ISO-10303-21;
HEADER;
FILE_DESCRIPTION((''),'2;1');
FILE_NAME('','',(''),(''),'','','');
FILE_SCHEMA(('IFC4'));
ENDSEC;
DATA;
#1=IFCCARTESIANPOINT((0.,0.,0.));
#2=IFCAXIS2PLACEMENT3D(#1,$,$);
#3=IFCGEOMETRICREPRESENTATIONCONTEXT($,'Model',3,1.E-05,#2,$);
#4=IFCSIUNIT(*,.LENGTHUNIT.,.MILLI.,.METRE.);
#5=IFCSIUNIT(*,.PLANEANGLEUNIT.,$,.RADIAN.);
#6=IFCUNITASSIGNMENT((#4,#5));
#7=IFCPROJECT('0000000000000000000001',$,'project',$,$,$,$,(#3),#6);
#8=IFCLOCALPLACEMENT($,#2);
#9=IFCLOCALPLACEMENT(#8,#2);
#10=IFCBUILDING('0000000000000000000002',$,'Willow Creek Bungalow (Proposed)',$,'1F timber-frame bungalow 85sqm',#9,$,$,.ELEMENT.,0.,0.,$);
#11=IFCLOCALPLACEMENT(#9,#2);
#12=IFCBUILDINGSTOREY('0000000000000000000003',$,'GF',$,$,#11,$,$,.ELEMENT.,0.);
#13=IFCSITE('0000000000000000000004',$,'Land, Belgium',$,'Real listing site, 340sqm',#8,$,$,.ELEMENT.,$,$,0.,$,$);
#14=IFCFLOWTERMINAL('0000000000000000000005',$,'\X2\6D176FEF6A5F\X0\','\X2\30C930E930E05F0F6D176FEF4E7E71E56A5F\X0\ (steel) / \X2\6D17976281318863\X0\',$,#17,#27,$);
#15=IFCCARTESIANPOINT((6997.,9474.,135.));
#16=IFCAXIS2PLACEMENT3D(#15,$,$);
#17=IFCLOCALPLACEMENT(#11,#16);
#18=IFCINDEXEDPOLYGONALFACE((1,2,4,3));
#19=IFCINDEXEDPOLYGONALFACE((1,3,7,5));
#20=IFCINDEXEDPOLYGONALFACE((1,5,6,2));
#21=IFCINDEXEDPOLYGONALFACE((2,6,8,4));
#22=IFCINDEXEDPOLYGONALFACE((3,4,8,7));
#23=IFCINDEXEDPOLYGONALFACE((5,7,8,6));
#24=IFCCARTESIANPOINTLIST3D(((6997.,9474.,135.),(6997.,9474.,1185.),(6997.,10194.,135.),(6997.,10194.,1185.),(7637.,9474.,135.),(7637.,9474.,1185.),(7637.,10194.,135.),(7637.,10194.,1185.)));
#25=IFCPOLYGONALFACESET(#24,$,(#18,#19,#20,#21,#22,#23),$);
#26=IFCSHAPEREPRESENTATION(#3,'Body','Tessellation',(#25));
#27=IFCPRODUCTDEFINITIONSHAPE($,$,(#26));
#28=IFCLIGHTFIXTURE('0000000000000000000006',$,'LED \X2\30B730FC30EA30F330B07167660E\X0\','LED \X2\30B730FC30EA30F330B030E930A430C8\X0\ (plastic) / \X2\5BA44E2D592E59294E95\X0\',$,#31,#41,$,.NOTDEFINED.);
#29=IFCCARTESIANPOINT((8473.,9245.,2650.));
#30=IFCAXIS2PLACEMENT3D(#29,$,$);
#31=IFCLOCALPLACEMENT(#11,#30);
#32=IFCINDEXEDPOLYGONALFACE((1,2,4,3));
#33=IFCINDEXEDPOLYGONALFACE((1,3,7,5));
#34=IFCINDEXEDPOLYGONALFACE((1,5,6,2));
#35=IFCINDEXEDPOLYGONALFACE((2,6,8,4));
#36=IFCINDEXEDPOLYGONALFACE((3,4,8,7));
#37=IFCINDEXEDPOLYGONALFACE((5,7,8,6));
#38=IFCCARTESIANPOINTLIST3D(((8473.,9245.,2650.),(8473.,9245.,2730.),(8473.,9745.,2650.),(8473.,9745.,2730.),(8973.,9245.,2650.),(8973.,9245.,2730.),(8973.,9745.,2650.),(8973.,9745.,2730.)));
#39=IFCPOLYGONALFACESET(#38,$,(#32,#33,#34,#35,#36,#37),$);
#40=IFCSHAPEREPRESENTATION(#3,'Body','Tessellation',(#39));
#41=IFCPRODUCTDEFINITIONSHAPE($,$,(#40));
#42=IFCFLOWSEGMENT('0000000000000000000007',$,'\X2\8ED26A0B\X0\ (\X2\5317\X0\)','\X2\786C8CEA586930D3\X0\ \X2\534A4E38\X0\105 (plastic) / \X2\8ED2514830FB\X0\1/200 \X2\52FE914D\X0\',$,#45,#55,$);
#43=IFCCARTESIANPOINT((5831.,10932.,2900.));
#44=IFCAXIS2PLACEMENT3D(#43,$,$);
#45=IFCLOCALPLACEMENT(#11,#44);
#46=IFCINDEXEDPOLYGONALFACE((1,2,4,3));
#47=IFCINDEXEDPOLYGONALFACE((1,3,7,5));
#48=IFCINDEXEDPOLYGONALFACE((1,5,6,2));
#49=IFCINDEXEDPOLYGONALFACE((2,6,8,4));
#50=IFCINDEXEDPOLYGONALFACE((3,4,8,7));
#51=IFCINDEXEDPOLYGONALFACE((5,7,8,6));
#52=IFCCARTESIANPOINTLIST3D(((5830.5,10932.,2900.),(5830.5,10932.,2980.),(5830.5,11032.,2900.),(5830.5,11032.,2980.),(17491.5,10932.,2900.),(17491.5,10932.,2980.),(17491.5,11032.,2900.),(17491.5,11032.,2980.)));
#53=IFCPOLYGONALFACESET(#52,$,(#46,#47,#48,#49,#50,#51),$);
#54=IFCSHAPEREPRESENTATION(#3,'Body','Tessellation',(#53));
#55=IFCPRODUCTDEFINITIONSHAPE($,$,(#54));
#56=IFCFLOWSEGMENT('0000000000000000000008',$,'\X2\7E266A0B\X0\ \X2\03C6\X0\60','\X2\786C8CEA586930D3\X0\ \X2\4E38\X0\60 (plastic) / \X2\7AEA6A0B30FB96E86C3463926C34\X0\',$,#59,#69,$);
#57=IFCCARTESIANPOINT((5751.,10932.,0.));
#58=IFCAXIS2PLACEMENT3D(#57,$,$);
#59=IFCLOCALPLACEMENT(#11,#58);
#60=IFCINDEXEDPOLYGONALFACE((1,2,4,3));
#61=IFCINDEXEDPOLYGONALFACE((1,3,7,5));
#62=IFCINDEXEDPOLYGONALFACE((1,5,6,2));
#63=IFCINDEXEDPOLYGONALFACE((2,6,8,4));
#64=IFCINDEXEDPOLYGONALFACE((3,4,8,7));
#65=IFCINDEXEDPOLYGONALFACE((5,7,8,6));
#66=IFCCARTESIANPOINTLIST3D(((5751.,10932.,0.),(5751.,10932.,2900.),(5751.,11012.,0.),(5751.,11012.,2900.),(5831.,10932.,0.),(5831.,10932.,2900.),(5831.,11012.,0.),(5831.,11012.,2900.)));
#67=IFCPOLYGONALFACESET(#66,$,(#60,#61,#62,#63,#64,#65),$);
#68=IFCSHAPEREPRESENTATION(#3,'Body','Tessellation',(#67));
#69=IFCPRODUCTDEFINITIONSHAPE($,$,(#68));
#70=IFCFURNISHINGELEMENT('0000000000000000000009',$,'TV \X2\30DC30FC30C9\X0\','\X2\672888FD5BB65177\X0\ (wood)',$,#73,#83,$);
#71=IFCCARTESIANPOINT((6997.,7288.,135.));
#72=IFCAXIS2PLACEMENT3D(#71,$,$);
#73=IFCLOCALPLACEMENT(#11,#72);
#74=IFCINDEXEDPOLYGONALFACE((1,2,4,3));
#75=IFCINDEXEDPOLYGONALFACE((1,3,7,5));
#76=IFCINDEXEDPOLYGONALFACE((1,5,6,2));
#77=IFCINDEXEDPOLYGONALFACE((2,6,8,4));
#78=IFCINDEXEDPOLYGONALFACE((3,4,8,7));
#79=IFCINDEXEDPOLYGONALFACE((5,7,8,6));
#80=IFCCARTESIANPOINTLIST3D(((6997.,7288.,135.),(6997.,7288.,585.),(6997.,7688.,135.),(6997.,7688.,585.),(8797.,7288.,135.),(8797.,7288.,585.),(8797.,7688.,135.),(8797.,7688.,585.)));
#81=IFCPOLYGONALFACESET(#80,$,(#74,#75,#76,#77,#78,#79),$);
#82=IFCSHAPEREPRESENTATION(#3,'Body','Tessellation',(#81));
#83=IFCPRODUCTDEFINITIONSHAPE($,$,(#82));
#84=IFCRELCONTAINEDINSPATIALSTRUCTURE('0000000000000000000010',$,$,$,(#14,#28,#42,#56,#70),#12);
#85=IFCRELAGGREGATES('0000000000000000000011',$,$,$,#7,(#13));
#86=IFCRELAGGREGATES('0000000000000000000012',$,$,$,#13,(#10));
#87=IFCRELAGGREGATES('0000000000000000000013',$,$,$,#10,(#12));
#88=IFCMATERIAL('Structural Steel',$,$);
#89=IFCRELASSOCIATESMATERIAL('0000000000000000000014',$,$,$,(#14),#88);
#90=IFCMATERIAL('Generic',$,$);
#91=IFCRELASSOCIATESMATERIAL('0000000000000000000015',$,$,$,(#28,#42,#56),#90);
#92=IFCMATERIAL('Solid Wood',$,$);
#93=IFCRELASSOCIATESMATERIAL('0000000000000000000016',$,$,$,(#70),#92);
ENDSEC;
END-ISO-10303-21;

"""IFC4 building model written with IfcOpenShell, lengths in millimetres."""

from ifc_helpers import new_model, si_unit, frame, frame_2d, origin, place, context, project, spatial, rectangle, extrude, material, element, save


model = new_model("IFC4")

# Units and contexts
model_context = context("Model", 3, precision=1e-05, world=origin())
ifc_project = project(units=[si_unit("LENGTHUNIT", "METRE", prefix="MILLI"), si_unit("PLANEANGLEUNIT", "RADIAN")], contexts=[model_context])

# Site, building, storey
site_placement = place(None, origin())
site = spatial("IfcSite", under=ifc_project, at=site_placement, Name="Land, Belgium", ObjectType="Real listing site, 340sqm", CompositionType="ELEMENT", RefElevation=0.0)
building_placement = place(site_placement, origin())
building = spatial("IfcBuilding", under=site, at=building_placement, Name="Willow Creek Bungalow (Proposed)", ObjectType="1F timber-frame bungalow 85sqm", CompositionType="ELEMENT", ElevationOfRefHeight=0.0, ElevationOfTerrain=0.0)
storey_placement = place(building_placement, origin())
storey = spatial("IfcBuildingStorey", under=building, at=storey_placement, Name="GF", CompositionType="ELEMENT", Elevation=0.0)

# Shared definitions
ifc_material_1 = material(Name="Solid Wood")

# Shared definitions
ifc_material_2 = material(Name="Structural Steel")

# Shared definitions
ifc_material_3 = material(Name="Generic")

# Flow terminal
flow_terminal_placement = place(storey_placement, frame((6997.0, 9474.0, 135.0)))
element("IfcFlowTerminal", 1, at=flow_terminal_placement, inside=storey, material=ifc_material_2, Name="洗濯機", Description="ドラム式洗濯乾燥機 (steel) / 洗面脱衣", context=model_context, shape_type="SweptSolid", body=[
    extrude(rectangle(XDim=640.0, YDim=720.0, at=frame_2d((320.0, 360.0))), frame((6997.0, 9474.0, 135.0)), (0.0, 0.0, 1.0), 1050.0),
])

# Light fixture
light_fixture_placement = place(storey_placement, frame((8473.0, 9245.0, 2650.0)))
element("IfcLightFixture", 2, at=light_fixture_placement, inside=storey, material=ifc_material_3, Name="LED シーリング照明", Description="LED シーリングライト (plastic) / 室中央天井", PredefinedType="NOTDEFINED", context=model_context, shape_type="SweptSolid", body=[
    extrude(rectangle(XDim=500.0, YDim=500.0, at=frame_2d((250.0, 250.0))), frame((8473.0, 9245.0, 2650.0)), (0.0, 0.0, 1.0), 80.0),
])

# Flow segments
flow_segment_1_placement = place(storey_placement, frame((5831.0, 10932.0, 2900.0)))
element("IfcFlowSegment", 3, at=flow_segment_1_placement, inside=storey, material=ifc_material_3, Name="軒樋 (北)", Description="硬質塩ビ 半丸105 (plastic) / 軒先・1/200 勾配", context=model_context, shape_type="SweptSolid", body=[
    extrude(rectangle(XDim=11661.0, YDim=100.0, at=frame_2d((5830.0, 50.0))), frame((5831.0, 10932.0, 2900.0)), (0.0, 0.0, 1.0), 80.0),
])
flow_segment_2_placement = place(storey_placement, frame((5751.0, 10932.0, 0.0)))
element("IfcFlowSegment", 4, at=flow_segment_2_placement, inside=storey, material=ifc_material_3, Name="縦樋 φ60", Description="硬質塩ビ 丸60 (plastic) / 竪樋・雨水排水", context=model_context, shape_type="SweptSolid", body=[
    extrude(rectangle(XDim=80.0, YDim=80.0, at=frame_2d((40.0, 40.0))), frame((5751.0, 10932.0, 0.0)), (0.0, 0.0, 1.0), 2900.0),
])

# Furnishing element
furnishing_placement = place(storey_placement, frame((6997.0, 7288.0, 135.0)))
element("IfcFurnishingElement", 5, at=furnishing_placement, inside=storey, material=ifc_material_1, Name="TV ボード", Description="木製家具 (wood)", context=model_context, shape_type="SweptSolid", body=[
    extrude(rectangle(XDim=1800.0, YDim=400.0, at=frame_2d((900.0, 200.0))), frame((6997.0, 7288.0, 135.0)), (0.0, 0.0, 1.0), 450.0),
])

save(model, "model.ifc")
